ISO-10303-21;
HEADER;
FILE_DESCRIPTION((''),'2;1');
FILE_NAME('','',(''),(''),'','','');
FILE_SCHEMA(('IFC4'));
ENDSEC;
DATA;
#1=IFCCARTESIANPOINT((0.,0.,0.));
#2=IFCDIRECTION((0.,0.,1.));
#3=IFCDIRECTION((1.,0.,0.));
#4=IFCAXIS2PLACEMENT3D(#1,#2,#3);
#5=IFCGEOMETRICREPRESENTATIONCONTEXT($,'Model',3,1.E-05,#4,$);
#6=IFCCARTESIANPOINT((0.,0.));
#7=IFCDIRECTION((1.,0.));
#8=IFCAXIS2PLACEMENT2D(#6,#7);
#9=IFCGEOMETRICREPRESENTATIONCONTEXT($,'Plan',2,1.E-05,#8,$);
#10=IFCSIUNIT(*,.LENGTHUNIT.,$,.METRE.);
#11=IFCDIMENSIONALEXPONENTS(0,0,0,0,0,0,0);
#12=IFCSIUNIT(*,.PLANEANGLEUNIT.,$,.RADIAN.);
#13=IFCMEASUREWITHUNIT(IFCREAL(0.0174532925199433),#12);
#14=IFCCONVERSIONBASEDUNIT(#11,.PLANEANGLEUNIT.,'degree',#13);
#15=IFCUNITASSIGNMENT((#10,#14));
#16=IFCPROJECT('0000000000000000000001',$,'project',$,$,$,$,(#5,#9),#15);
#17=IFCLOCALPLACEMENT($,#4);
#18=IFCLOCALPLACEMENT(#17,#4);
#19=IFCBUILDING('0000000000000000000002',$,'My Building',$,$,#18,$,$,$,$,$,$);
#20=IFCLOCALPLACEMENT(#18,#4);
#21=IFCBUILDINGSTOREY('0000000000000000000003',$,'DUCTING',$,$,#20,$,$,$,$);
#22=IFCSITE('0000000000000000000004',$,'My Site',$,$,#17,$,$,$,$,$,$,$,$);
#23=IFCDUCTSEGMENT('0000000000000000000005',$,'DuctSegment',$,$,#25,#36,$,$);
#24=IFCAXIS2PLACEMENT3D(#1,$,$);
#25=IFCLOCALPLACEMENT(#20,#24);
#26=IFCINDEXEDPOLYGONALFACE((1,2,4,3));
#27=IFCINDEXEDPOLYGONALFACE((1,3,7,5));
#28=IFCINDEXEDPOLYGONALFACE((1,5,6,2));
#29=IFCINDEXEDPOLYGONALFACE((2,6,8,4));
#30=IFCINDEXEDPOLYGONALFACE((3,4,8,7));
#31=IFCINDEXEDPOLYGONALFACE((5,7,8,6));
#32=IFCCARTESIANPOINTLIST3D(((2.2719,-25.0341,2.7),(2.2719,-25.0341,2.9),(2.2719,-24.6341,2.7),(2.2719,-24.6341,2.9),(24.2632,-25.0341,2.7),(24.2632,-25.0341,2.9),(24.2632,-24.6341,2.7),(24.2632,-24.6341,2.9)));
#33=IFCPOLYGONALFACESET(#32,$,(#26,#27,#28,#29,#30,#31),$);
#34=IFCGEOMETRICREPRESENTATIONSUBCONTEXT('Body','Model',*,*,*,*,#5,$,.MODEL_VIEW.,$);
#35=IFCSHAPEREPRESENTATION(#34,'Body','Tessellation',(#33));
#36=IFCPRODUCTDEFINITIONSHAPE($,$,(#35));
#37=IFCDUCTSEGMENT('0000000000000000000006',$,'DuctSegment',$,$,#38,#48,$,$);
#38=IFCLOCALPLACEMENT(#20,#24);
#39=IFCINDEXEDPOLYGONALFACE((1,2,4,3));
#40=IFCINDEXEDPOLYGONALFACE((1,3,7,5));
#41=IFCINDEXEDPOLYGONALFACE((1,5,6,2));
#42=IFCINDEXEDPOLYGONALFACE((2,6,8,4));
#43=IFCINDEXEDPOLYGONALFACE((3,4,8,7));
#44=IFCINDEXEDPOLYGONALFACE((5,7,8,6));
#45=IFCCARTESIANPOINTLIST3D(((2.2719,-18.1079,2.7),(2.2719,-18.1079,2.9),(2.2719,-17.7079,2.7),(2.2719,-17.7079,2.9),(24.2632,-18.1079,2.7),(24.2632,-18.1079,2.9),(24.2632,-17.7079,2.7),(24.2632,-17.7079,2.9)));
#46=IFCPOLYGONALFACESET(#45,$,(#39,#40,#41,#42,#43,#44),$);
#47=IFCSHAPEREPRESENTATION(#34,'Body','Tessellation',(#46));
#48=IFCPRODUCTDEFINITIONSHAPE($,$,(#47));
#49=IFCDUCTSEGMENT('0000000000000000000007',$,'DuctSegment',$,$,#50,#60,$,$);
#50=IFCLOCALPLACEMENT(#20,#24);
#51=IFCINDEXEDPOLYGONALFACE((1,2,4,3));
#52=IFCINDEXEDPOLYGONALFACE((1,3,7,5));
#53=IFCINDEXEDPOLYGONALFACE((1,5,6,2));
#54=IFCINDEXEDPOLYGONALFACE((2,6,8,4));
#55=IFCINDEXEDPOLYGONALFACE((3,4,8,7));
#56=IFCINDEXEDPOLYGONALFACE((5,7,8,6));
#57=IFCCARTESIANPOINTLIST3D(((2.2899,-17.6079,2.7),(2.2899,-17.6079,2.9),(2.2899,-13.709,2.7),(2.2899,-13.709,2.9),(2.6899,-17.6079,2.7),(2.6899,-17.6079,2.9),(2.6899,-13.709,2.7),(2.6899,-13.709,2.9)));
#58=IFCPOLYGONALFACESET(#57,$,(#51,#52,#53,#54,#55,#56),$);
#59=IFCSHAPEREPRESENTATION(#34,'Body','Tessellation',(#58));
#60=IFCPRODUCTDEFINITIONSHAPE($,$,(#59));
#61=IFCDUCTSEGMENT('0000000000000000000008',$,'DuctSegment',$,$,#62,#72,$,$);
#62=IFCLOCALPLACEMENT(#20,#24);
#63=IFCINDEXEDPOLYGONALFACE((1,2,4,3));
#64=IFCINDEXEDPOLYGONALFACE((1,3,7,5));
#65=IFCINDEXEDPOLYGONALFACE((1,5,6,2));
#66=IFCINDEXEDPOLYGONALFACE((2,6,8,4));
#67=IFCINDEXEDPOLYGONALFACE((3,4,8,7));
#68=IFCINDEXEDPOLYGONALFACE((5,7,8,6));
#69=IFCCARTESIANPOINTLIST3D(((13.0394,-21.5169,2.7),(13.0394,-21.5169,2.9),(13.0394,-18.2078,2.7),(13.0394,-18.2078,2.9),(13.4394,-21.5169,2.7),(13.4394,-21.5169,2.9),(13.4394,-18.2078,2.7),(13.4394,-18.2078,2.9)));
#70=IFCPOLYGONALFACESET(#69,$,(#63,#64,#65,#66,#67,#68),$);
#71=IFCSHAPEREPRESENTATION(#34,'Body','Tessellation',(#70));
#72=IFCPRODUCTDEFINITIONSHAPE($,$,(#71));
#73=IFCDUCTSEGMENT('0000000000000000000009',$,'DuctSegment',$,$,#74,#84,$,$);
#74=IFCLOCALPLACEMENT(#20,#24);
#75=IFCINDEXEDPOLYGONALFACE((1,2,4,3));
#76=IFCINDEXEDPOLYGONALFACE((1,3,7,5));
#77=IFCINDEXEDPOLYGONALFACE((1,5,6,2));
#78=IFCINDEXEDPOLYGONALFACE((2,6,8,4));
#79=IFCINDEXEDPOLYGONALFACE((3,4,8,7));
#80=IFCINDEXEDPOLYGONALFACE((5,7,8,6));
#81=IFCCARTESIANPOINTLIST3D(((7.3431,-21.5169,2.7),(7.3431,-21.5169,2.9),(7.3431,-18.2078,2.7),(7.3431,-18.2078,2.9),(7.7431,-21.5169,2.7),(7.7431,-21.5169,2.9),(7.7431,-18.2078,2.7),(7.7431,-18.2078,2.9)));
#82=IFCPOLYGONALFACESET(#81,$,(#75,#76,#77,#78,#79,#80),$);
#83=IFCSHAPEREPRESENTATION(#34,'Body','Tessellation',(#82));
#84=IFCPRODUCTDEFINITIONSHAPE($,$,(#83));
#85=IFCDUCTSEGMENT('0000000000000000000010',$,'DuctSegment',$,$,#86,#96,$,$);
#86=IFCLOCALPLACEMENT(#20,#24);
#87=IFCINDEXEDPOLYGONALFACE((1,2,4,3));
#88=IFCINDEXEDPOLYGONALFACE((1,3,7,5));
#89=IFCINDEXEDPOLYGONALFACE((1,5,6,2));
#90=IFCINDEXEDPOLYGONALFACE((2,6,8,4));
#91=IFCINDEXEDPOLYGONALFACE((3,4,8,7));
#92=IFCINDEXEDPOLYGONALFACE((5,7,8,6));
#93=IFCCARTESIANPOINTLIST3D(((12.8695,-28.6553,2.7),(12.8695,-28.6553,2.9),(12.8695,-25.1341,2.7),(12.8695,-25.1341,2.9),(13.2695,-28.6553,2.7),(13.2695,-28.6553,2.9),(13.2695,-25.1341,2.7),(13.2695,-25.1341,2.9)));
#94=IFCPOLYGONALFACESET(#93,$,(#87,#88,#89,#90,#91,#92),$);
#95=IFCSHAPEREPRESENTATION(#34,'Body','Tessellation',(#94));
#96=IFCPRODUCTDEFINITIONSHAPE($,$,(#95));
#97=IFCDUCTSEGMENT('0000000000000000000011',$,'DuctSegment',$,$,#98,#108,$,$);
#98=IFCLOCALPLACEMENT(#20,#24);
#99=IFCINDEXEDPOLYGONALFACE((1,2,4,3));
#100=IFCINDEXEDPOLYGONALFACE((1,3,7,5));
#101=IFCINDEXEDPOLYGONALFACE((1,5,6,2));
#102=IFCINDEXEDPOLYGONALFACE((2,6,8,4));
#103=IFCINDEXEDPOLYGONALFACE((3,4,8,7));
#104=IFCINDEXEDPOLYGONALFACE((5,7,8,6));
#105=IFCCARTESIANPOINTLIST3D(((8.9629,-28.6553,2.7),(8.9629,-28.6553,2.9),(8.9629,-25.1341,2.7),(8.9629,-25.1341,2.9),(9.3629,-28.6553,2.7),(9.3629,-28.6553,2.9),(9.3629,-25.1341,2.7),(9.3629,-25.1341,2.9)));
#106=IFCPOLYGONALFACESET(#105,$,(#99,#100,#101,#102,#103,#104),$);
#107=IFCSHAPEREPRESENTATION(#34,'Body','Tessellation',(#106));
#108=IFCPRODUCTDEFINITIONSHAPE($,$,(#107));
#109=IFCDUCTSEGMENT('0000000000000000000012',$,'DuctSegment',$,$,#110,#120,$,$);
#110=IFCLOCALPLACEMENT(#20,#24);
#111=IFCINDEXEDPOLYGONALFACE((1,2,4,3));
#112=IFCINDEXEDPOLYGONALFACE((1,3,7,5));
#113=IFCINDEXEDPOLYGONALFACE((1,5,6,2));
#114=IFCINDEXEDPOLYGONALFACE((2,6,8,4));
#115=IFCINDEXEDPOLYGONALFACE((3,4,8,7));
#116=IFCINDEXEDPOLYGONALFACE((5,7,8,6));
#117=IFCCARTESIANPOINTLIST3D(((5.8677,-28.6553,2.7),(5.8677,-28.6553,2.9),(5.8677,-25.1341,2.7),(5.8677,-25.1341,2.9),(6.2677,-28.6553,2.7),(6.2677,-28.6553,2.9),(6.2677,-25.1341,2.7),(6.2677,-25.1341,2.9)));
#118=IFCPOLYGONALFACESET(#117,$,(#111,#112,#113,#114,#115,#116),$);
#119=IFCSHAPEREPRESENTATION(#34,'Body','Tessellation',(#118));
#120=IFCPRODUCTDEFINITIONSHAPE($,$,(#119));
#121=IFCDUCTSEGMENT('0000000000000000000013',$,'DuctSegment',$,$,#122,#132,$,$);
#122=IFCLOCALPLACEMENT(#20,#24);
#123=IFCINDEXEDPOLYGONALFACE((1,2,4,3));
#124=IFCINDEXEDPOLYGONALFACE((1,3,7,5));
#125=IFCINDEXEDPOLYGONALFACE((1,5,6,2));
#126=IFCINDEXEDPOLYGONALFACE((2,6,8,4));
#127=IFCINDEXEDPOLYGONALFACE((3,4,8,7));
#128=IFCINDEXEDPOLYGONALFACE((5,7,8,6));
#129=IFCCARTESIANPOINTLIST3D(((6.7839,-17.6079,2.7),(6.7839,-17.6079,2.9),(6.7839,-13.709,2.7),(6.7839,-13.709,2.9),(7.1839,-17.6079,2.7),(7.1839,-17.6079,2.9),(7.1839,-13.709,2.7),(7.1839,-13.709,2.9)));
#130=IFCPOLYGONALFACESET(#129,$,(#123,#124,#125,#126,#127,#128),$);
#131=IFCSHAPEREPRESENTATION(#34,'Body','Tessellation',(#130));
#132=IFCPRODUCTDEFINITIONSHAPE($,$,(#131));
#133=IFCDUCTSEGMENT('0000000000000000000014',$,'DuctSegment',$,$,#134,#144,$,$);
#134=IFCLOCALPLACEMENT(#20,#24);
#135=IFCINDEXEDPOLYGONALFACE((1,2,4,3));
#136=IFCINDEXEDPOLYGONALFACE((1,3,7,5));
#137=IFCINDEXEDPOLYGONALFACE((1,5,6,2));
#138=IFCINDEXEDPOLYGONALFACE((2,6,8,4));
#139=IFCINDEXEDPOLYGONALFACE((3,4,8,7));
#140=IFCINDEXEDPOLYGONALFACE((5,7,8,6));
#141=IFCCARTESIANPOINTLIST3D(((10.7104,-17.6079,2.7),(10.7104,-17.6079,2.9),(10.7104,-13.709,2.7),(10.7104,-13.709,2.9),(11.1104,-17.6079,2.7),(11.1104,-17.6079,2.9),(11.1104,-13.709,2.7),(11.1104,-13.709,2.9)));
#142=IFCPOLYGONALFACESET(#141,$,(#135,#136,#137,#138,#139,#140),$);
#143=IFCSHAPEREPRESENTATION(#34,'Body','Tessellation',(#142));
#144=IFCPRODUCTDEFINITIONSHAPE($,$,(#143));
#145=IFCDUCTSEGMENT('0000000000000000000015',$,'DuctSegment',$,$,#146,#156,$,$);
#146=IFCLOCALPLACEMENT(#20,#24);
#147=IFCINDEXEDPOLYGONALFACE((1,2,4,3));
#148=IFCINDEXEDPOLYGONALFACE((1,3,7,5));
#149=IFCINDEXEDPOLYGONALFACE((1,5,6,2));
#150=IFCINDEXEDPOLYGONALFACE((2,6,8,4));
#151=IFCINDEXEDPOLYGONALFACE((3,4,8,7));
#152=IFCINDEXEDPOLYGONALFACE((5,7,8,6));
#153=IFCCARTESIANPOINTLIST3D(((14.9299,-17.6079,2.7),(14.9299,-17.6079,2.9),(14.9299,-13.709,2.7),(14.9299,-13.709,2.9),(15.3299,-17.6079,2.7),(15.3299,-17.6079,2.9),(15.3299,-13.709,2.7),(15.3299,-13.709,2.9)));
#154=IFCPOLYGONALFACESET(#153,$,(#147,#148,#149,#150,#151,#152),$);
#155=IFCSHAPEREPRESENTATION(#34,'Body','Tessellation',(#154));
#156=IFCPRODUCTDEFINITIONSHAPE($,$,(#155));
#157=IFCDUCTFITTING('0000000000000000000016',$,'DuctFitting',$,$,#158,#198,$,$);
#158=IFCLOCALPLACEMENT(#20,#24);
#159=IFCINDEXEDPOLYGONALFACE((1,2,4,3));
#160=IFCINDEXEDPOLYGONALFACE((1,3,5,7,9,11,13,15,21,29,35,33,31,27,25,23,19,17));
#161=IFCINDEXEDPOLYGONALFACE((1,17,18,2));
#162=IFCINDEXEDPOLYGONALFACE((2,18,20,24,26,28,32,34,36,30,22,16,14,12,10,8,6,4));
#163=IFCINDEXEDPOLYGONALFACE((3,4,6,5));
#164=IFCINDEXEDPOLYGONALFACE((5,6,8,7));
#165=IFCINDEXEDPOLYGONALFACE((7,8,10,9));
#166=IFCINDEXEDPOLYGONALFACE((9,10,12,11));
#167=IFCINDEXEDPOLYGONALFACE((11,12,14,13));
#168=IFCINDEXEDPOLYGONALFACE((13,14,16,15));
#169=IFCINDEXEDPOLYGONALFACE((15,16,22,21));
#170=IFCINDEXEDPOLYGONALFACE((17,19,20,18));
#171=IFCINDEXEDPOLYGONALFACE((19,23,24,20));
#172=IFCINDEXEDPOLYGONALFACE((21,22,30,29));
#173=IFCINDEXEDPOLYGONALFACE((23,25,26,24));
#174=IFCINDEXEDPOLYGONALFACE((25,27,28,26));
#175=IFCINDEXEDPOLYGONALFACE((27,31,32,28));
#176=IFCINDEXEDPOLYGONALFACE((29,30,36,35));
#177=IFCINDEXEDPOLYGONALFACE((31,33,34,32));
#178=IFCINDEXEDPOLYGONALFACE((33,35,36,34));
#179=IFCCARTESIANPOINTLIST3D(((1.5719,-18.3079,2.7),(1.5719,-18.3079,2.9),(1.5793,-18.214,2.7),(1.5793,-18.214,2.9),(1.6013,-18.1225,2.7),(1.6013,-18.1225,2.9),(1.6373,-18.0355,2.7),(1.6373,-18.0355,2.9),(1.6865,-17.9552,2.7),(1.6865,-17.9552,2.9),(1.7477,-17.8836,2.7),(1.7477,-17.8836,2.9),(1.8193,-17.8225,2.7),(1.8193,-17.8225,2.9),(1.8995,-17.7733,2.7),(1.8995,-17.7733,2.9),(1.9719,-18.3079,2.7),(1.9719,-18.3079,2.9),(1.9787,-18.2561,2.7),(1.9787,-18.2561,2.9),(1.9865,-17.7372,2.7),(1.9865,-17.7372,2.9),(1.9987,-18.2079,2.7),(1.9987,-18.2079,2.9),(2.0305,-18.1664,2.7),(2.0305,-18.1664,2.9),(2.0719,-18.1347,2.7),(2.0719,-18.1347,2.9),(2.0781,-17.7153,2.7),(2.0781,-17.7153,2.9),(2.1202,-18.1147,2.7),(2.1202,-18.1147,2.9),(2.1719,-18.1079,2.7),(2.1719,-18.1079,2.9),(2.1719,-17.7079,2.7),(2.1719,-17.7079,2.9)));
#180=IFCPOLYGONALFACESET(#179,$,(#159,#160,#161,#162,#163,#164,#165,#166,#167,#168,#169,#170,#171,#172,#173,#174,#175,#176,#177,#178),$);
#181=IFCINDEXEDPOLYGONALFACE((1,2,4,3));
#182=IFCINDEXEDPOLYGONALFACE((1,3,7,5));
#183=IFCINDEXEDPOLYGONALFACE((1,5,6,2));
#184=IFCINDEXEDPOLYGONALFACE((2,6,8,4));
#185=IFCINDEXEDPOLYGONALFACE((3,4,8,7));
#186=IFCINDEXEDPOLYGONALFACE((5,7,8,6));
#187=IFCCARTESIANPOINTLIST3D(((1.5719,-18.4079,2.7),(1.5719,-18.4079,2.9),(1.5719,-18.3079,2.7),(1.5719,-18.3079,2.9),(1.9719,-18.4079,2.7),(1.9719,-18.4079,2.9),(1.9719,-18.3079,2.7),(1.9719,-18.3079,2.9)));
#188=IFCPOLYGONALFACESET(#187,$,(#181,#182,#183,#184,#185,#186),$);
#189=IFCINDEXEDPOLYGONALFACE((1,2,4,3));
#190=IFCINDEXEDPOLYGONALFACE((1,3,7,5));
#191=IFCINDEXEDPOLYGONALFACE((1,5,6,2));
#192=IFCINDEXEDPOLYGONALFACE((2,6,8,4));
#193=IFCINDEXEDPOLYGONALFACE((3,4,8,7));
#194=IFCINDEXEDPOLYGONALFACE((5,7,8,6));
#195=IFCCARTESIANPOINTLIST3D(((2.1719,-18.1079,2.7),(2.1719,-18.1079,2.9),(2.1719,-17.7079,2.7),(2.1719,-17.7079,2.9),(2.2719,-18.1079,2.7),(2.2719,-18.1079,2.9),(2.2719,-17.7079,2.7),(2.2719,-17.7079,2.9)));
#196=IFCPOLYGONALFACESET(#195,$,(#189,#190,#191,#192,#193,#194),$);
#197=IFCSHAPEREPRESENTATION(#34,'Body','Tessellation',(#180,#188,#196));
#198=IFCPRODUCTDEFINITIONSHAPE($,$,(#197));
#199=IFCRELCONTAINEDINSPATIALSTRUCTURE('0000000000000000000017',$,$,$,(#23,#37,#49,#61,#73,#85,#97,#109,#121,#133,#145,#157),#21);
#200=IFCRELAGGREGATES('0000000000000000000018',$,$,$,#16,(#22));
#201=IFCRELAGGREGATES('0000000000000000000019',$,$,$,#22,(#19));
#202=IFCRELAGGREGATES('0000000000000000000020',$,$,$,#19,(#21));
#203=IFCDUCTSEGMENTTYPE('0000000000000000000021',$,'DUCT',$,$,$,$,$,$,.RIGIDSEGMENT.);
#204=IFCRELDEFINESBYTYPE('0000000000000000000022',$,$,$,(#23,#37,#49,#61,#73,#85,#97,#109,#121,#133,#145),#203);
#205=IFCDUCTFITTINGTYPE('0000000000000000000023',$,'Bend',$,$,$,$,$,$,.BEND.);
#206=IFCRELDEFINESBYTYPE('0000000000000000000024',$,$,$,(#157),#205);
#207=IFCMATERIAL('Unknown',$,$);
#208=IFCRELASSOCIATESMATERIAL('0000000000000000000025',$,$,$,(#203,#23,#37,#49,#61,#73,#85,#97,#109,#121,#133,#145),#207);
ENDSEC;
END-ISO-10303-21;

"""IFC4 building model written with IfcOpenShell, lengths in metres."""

from ifc_helpers import new_model, entity, si_unit, converted_unit, frame, origin_with_axes, origin_2d_with_axis, place, context, subcontext, project, spatial, line, arc, indexed_curve, rectangle, outline, extrude, source, transform, mapped, material, material_profile, profile_set, profile_usage, type_object, type_shapes, element, save


model = new_model("IFC4")

# Units and contexts
model_context = context("Model", 3, precision=1e-05, world=origin_with_axes())
plan_context = context("Plan", 2, precision=1e-05, world=origin_2d_with_axis())
body_context = subcontext(model_context, "Body", "Model", "MODEL_VIEW")
ifc_project = project(units=[si_unit("LENGTHUNIT", "METRE"), converted_unit("PLANEANGLEUNIT", "degree", entity("IfcReal", 0.0174532925199433), si_unit("PLANEANGLEUNIT", "RADIAN"), dimensions=[0, 0, 0, 0, 0, 0, 0])], contexts=[model_context, plan_context])

# Site, building, storey
site_placement = place(None, origin_with_axes())
site = spatial("IfcSite", under=ifc_project, at=site_placement, Name="My Site")
building_placement = place(site_placement, origin_with_axes())
building = spatial("IfcBuilding", under=site, at=building_placement, Name="My Building")
storey_placement = place(building_placement, origin_with_axes())
storey = spatial("IfcBuildingStorey", under=building, at=storey_placement, Name="DUCTING")

# Duct segments
ifc_material = material(Name="Unknown")
ifc_material_profile_1 = material_profile(ifc_material, rectangle(XDim=0.4, YDim=0.2))
ifc_profile_set_1 = profile_set([ifc_material_profile_1])
ifc_profile_usage_1 = profile_usage(ifc_profile_set_1, cardinal=5)
duct_segment_type = type_object("IfcDuctSegmentType", Name="DUCT", PredefinedType="RIGIDSEGMENT", material=ifc_profile_set_1)
duct_segment_1_placement = place(storey_placement, frame((2.2719, -24.8341, 2.8), z_axis=(1.0, 0.0, 0.0), x_axis=(0.0, 1.0, 0.0)))
element("IfcDuctSegment", 1, at=duct_segment_1_placement, inside=storey, type_object=duct_segment_type, material=ifc_profile_usage_1, Name="DuctSegment", context=body_context, shape_type="SweptSolid", body=[
    extrude(rectangle(XDim=0.4, YDim=0.2), origin_with_axes(), (0.0, 0.0, 1.0), 21.9913),
])
ifc_profile_usage_2 = profile_usage(ifc_profile_set_1, cardinal=5)
duct_segment_2_placement = place(storey_placement, frame((2.2719, -17.9079, 2.8), z_axis=(1.0, 0.0, 0.0), x_axis=(0.0, 1.0, 0.0)))
element("IfcDuctSegment", 2, at=duct_segment_2_placement, inside=storey, type_object=duct_segment_type, material=ifc_profile_usage_2, Name="DuctSegment", context=body_context, shape_type="SweptSolid", body=[
    extrude(rectangle(XDim=0.4, YDim=0.2), origin_with_axes(), (0.0, 0.0, 1.0), 21.9913),
])
ifc_profile_usage_3 = profile_usage(ifc_profile_set_1, cardinal=5)
duct_segment_3_placement = place(storey_placement, frame((2.4899, -13.709, 2.8), z_axis=(0.0, -1.0, 0.0), x_axis=(1.0, 0.0, 0.0)))
element("IfcDuctSegment", 3, at=duct_segment_3_placement, inside=storey, type_object=duct_segment_type, material=ifc_profile_usage_3, Name="DuctSegment", context=body_context, shape_type="SweptSolid", body=[
    extrude(rectangle(XDim=0.4, YDim=0.2), origin_with_axes(), (0.0, 0.0, 1.0), 3.8989),
])
ifc_profile_usage_4 = profile_usage(ifc_profile_set_1, cardinal=5)
duct_segment_4_placement = place(storey_placement, frame((13.2394, -21.5169, 2.8), z_axis=(0.0, 1.0, 0.0), x_axis=(-1.0, 0.0, 0.0)))
element("IfcDuctSegment", 4, at=duct_segment_4_placement, inside=storey, type_object=duct_segment_type, material=ifc_profile_usage_4, Name="DuctSegment", context=body_context, shape_type="SweptSolid", body=[
    extrude(rectangle(XDim=0.4, YDim=0.2), origin_with_axes(), (0.0, 0.0, 1.0), 3.309),
])
ifc_profile_usage_5 = profile_usage(ifc_profile_set_1, cardinal=5)
duct_segment_5_placement = place(storey_placement, frame((7.5431, -21.5169, 2.8), z_axis=(0.0, 1.0, 0.0), x_axis=(-1.0, 0.0, 0.0)))
element("IfcDuctSegment", 5, at=duct_segment_5_placement, inside=storey, type_object=duct_segment_type, material=ifc_profile_usage_5, Name="DuctSegment", context=body_context, shape_type="SweptSolid", body=[
    extrude(rectangle(XDim=0.4, YDim=0.2), origin_with_axes(), (0.0, 0.0, 1.0), 3.309),
])
ifc_profile_usage_6 = profile_usage(ifc_profile_set_1, cardinal=5)
duct_segment_6_placement = place(storey_placement, frame((13.0695, -28.6553, 2.8), z_axis=(0.0, 1.0, 0.0), x_axis=(-1.0, 0.0, 0.0)))
element("IfcDuctSegment", 6, at=duct_segment_6_placement, inside=storey, type_object=duct_segment_type, material=ifc_profile_usage_6, Name="DuctSegment", context=body_context, shape_type="SweptSolid", body=[
    extrude(rectangle(XDim=0.4, YDim=0.2), origin_with_axes(), (0.0, 0.0, 1.0), 3.5212),
])
ifc_profile_usage_7 = profile_usage(ifc_profile_set_1, cardinal=5)
duct_segment_7_placement = place(storey_placement, frame((9.1629, -28.6553, 2.8), z_axis=(0.0, 1.0, 0.0), x_axis=(-1.0, 0.0, 0.0)))
element("IfcDuctSegment", 7, at=duct_segment_7_placement, inside=storey, type_object=duct_segment_type, material=ifc_profile_usage_7, Name="DuctSegment", context=body_context, shape_type="SweptSolid", body=[
    extrude(rectangle(XDim=0.4, YDim=0.2), origin_with_axes(), (0.0, 0.0, 1.0), 3.5212),
])
ifc_profile_usage_8 = profile_usage(ifc_profile_set_1, cardinal=5)
duct_segment_8_placement = place(storey_placement, frame((6.0677, -28.6553, 2.8), z_axis=(0.0, 1.0, 0.0), x_axis=(-1.0, 0.0, 0.0)))
element("IfcDuctSegment", 8, at=duct_segment_8_placement, inside=storey, type_object=duct_segment_type, material=ifc_profile_usage_8, Name="DuctSegment", context=body_context, shape_type="SweptSolid", body=[
    extrude(rectangle(XDim=0.4, YDim=0.2), origin_with_axes(), (0.0, 0.0, 1.0), 3.5212),
])
ifc_profile_usage_9 = profile_usage(ifc_profile_set_1, cardinal=5)
duct_segment_9_placement = place(storey_placement, frame((6.9839, -13.709, 2.8), z_axis=(0.0, -1.0, 0.0), x_axis=(1.0, 0.0, 0.0)))
element("IfcDuctSegment", 9, at=duct_segment_9_placement, inside=storey, type_object=duct_segment_type, material=ifc_profile_usage_9, Name="DuctSegment", context=body_context, shape_type="SweptSolid", body=[
    extrude(rectangle(XDim=0.4, YDim=0.2), origin_with_axes(), (0.0, 0.0, 1.0), 3.8989),
])
ifc_profile_usage_10 = profile_usage(ifc_profile_set_1, cardinal=5)
duct_segment_10_placement = place(storey_placement, frame((10.9104, -13.709, 2.8), z_axis=(0.0, -1.0, 0.0), x_axis=(1.0, 0.0, 0.0)))
element("IfcDuctSegment", 10, at=duct_segment_10_placement, inside=storey, type_object=duct_segment_type, material=ifc_profile_usage_10, Name="DuctSegment", context=body_context, shape_type="SweptSolid", body=[
    extrude(rectangle(XDim=0.4, YDim=0.2), origin_with_axes(), (0.0, 0.0, 1.0), 3.8989),
])
ifc_profile_usage_11 = profile_usage(ifc_profile_set_1, cardinal=5)
duct_segment_11_placement = place(storey_placement, frame((15.1299, -13.709, 2.8), z_axis=(0.0, -1.0, 0.0), x_axis=(1.0, 0.0, 0.0)))
element("IfcDuctSegment", 11, at=duct_segment_11_placement, inside=storey, type_object=duct_segment_type, material=ifc_profile_usage_11, Name="DuctSegment", context=body_context, shape_type="SweptSolid", body=[
    extrude(rectangle(XDim=0.4, YDim=0.2), origin_with_axes(), (0.0, 0.0, 1.0), 3.8989),
])

# Duct fitting
duct_fitting_type_1 = type_object("IfcDuctFittingType", Name="Bend", PredefinedType="BEND")
shared_shape = source(origin_with_axes(), body_context, "Body", "SweptSolid", [
    extrude(outline(indexed_curve([(-0.2, 0.0), (-0.2586, 0.1414), (-0.4, 0.2), (-0.4, 0.6), (0.0243, 0.4243), (0.2, 0.0)], segments=[arc(1, 2, 3), line(3, 4), arc(4, 5, 6), line(6, 1)])), frame((0.0, -0.1, 0.1), z_axis=(0.0, -1.0, 0.0), x_axis=(1.0, 0.0, 0.0)), (0.0, 0.0, -1.0), 0.2),
    extrude(rectangle(XDim=0.4, YDim=0.2), origin_with_axes(), (0.0, 0.0, 1.0), 0.1),
    extrude(rectangle(XDim=0.4, YDim=0.2), frame((-0.4, 0.0, 0.5), z_axis=(-1.0, 0.0, 0.0), x_axis=(0.0, 0.0, -1.0)), (0.0, 0.0, 1.0), 0.1),
])
type_shapes(duct_fitting_type_1, [shared_shape])
for number, where, z_axis, x_axis, name in (
    (12, (1.7719, -18.4079, 2.8), (0.0, 1.0, 0.0), (-1.0, 0.0, 0.0), "DuctFitting"),
):
    element("IfcDuctFitting", number, at=place(storey_placement, frame(where, z_axis=z_axis, x_axis=x_axis)), inside=storey, type_object=duct_fitting_type_1, Name=name, context=body_context, shape_type="MappedRepresentation", body=[
        mapped(shared_shape, transform((0.0, 0.0, 0.0), x_axis=(1.0, 0.0, 0.0), y_axis=(0.0, 1.0, 0.0), z_axis=(0.0, 0.0, 1.0), scale=1.0)),
    ])

save(model, "model.ifc")
